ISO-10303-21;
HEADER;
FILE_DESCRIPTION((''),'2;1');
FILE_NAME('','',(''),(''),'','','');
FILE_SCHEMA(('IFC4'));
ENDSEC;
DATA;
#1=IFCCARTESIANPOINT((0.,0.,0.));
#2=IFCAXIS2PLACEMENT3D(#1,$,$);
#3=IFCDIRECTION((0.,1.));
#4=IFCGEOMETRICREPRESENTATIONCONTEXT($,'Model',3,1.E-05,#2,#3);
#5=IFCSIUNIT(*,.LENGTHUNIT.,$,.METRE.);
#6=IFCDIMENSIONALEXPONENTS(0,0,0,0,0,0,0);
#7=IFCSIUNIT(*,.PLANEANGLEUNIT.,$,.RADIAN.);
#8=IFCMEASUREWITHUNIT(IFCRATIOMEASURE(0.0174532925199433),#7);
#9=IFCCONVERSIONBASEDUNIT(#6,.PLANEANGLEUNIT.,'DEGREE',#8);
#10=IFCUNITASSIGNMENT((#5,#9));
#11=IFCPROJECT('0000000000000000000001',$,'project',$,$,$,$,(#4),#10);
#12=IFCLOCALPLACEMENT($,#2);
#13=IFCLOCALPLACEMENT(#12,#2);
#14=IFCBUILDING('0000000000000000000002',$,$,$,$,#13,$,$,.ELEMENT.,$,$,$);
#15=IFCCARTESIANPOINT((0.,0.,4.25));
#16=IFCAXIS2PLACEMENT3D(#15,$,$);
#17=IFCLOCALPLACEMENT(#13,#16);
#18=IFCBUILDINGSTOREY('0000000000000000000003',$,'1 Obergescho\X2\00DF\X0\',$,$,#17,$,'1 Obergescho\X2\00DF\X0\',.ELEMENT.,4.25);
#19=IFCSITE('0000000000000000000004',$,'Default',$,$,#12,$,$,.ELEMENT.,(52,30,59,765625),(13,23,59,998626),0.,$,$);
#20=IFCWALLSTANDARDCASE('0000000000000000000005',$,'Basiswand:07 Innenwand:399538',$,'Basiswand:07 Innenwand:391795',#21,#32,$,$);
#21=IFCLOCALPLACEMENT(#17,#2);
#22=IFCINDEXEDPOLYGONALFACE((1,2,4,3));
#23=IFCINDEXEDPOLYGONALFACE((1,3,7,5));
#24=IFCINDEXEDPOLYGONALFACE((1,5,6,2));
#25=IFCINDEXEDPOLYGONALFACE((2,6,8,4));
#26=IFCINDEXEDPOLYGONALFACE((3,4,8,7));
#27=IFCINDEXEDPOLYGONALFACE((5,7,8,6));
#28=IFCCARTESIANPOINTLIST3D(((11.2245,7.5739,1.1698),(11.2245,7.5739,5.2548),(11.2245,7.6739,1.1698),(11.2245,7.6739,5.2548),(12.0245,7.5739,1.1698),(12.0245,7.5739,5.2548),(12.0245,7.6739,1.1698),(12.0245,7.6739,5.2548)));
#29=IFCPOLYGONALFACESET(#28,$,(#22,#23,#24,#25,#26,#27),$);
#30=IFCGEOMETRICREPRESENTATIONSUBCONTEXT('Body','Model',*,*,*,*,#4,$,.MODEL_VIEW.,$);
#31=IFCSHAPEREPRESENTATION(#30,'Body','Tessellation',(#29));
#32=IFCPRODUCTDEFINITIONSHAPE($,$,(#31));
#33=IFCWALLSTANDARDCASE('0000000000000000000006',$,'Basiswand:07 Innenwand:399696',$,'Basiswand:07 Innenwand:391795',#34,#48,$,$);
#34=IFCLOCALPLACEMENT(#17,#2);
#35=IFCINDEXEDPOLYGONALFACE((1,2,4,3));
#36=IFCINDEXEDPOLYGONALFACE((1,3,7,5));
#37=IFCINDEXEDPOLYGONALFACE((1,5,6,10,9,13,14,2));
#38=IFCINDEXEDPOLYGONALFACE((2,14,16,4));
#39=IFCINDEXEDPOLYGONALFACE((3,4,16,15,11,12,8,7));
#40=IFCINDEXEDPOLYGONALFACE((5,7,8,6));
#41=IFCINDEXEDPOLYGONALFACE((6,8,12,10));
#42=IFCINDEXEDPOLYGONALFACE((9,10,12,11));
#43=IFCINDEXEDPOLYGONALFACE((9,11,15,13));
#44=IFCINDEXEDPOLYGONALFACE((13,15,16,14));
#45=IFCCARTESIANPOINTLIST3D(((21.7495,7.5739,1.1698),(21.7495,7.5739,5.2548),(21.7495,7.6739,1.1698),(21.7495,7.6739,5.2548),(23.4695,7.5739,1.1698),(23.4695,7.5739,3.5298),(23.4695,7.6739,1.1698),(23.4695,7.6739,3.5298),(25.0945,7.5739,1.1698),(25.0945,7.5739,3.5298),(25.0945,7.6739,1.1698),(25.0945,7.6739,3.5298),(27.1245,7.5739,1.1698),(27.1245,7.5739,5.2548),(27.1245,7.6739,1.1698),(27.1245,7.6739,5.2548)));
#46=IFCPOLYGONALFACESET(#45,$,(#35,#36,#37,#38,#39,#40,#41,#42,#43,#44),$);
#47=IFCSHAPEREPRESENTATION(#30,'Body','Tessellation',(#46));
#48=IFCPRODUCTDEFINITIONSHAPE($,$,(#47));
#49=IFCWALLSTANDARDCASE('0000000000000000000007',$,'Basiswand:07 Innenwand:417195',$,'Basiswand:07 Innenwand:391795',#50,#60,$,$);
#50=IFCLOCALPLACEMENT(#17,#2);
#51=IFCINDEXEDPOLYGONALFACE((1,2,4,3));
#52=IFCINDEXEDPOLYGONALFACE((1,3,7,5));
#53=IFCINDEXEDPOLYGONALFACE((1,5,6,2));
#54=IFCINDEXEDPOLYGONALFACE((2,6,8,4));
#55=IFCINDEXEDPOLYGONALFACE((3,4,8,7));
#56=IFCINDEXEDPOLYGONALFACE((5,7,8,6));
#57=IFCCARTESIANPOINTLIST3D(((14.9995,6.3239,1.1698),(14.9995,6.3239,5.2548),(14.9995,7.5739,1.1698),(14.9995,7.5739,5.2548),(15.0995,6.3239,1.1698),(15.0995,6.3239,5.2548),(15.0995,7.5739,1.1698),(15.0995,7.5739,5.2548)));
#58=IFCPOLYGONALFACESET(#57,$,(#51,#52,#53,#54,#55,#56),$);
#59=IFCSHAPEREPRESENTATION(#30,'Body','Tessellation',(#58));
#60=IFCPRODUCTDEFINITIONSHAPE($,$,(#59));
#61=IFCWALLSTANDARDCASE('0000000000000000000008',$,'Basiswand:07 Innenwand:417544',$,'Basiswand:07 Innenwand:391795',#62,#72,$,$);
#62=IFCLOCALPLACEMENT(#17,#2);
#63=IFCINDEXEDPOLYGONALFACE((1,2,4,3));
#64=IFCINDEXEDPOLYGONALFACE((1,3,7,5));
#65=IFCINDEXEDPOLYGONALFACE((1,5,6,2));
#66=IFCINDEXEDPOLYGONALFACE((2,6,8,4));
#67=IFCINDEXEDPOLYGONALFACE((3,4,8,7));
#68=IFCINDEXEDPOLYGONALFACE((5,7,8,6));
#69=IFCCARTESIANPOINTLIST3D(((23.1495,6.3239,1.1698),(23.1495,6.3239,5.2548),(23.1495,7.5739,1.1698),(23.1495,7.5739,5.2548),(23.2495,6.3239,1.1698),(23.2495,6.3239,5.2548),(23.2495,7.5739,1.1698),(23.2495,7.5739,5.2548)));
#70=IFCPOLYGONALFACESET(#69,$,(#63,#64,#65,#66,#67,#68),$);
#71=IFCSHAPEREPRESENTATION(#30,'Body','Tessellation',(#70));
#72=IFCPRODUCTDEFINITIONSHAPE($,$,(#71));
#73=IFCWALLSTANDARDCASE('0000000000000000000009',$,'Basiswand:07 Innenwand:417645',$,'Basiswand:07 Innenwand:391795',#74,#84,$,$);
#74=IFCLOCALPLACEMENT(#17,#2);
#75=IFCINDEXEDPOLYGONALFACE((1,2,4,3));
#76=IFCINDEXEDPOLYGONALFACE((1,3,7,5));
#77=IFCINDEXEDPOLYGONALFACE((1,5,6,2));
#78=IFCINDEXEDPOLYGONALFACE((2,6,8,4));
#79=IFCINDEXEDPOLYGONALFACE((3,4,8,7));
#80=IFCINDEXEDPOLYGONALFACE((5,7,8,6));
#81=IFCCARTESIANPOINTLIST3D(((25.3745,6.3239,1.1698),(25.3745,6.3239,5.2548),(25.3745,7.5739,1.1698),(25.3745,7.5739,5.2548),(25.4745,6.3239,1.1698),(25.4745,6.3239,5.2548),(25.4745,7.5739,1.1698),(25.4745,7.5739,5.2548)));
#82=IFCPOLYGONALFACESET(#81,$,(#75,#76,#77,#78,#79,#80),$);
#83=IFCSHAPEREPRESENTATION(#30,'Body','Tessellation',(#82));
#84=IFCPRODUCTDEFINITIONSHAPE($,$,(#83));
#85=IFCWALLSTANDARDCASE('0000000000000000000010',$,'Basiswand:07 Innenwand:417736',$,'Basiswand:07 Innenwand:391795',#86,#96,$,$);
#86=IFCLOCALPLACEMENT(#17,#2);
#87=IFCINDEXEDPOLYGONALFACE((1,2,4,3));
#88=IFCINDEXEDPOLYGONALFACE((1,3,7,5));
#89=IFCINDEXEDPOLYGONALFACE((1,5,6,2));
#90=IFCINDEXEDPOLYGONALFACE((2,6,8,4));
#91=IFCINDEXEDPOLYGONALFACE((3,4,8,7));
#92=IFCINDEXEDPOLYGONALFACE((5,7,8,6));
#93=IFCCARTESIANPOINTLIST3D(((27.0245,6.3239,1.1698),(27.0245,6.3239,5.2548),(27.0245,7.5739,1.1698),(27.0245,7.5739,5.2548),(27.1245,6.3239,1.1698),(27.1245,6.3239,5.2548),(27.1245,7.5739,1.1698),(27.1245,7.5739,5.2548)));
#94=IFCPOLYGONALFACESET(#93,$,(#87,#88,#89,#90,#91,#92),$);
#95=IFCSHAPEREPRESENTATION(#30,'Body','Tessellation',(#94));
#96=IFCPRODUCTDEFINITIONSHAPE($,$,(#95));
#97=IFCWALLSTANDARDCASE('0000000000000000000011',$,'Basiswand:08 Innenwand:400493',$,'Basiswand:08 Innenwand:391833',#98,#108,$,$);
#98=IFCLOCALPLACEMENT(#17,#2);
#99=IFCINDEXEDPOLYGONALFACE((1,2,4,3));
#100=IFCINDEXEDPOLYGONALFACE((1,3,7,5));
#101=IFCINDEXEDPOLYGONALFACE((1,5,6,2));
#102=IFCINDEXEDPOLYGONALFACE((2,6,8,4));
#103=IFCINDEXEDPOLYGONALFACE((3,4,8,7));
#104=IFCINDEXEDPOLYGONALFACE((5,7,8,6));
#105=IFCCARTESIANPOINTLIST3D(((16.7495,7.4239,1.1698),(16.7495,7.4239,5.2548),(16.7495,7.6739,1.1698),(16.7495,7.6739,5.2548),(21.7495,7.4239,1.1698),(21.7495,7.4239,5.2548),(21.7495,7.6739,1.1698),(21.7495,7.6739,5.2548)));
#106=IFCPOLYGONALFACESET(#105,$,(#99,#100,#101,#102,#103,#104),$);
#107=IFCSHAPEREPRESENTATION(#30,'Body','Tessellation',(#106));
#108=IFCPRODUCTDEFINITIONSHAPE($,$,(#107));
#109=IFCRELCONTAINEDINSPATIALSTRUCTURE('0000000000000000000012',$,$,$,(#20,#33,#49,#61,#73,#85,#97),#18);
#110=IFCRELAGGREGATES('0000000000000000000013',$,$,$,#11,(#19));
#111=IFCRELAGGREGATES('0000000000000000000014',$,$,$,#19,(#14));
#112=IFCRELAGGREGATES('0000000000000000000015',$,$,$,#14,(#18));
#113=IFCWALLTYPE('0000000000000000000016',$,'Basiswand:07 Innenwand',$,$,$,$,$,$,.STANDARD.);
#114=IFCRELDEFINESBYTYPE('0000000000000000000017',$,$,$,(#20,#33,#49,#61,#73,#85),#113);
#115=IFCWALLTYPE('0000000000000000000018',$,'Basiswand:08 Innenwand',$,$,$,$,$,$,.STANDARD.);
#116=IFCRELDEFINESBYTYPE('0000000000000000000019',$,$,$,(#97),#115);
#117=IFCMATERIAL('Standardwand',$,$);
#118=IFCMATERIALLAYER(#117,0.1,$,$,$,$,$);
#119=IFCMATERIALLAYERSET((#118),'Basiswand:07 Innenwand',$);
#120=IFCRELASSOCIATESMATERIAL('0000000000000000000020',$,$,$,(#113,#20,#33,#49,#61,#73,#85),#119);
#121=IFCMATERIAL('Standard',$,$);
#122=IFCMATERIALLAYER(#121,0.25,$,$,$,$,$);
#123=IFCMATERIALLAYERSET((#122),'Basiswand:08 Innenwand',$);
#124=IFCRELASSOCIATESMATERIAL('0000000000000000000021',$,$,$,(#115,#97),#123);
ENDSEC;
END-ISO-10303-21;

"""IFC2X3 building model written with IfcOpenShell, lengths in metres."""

from ifc_helpers import new_model, entity, si_unit, converted_unit, direction, frame, frame_2d, origin, place, context, subcontext, project, spatial, polyline, rectangle, extrude, clip, bounded_halfspace, material, layer, layer_set, layer_usage, type_object, element, save


model = new_model("IFC2X3")

# Units and contexts
model_context = context("Model", 3, precision=1e-05, world=origin(), true_north=direction((0.0, 1.0)))
body_context = subcontext(model_context, "Body", "Model", "MODEL_VIEW")
ifc_project = project(units=[si_unit("LENGTHUNIT", "METRE"), converted_unit("PLANEANGLEUNIT", "DEGREE", entity("IfcRatioMeasure", 0.0174532925199433), si_unit("PLANEANGLEUNIT", "RADIAN"), dimensions=[0, 0, 0, 0, 0, 0, 0])], contexts=[model_context])

# Site, building, storey
site_placement = place(None, origin())
site = spatial("IfcSite", under=ifc_project, at=site_placement, Name="Default", CompositionType="ELEMENT", RefLatitude=(52, 30, 59, 765625), RefLongitude=(13, 23, 59, 998626), RefElevation=0.0)
building_placement = place(site_placement, origin())
building = spatial("IfcBuilding", under=site, at=building_placement, CompositionType="ELEMENT")
storey_placement = place(building_placement, frame((0.0, 0.0, 4.25)))
storey = spatial("IfcBuildingStorey", under=building, at=storey_placement, Name="1 Obergeschoß", LongName="1 Obergeschoß", CompositionType="ELEMENT", Elevation=4.25)

# Shared definitions
ifc_material_1 = material(Name="Standardwand")
ifc_layer_1 = layer(ifc_material_1, 0.1)
ifc_layer_set_1 = layer_set([ifc_layer_1], Name="Basiswand:07 Innenwand")
wall_type_1 = type_object("IfcWallType", Name="Basiswand:07 Innenwand", PredefinedType="STANDARD", material=ifc_layer_set_1)

# Wall
ifc_layer_usage_1 = layer_usage(ifc_layer_set_1, "AXIS2", "NEGATIVE", 0.05)
wall_1_placement = place(storey_placement, frame((11.2245, 7.6239, 1.1698), z_axis=(0.0, 0.0, 1.0), x_axis=(1.0, 0.0, 0.0)))
element("IfcWallStandardCase", 1, at=wall_1_placement, inside=storey, type_object=wall_type_1, material=ifc_layer_usage_1, Name="Basiswand:07 Innenwand:399538", ObjectType="Basiswand:07 Innenwand:391795", context=body_context, shape_type="Clipping", body=[
    clip(extrude(rectangle(XDim=0.8, YDim=0.1, at=frame_2d((0.4, 0.0), x_axis=(-1.0, 0.0))), origin(), (0.0, 0.0, 1.0), 4.085), bounded_halfspace(frame((0.0, -0.05, 4.085), z_axis=(0.0, 0.0, -1.0), x_axis=(0.0, -1.0, 0.0)), True, frame((0.0, -0.05, 4.085)), polyline([(0.0, 0.0), (0.8, 0.0), (0.8, 0.1), (0.0, 0.1), (0.0, 0.0)]))),
])

# Wall, opening
ifc_layer_usage_2 = layer_usage(ifc_layer_set_1, "AXIS2", "POSITIVE", -0.05)
wall_2_placement = place(storey_placement, frame((21.7495, 7.6239, 1.1698), z_axis=(0.0, 0.0, 1.0), x_axis=(1.0, 0.0, 0.0)))
wall_2 = element("IfcWallStandardCase", 2, at=wall_2_placement, inside=storey, type_object=wall_type_1, material=ifc_layer_usage_2, Name="Basiswand:07 Innenwand:399696", ObjectType="Basiswand:07 Innenwand:391795", context=body_context, shape_type="Clipping", body=[
    clip(extrude(rectangle(XDim=5.375, YDim=0.1, at=frame_2d((2.6875, 0.0), x_axis=(-1.0, 0.0))), origin(), (0.0, 0.0, 1.0), 4.085), bounded_halfspace(frame((0.0, -0.05, 4.085), z_axis=(0.0, 0.0, -1.0), x_axis=(0.0, -1.0, 0.0)), True, frame((0.0, -0.05, 4.085)), polyline([(0.0, 0.0), (1.4, 0.0), (1.5, 0.0), (3.625, 0.0), (3.725, 0.0), (5.275, 0.0), (5.375, 0.0), (5.375, 0.1), (0.0, 0.1), (0.0, 0.0)]))),
])
opening_1_placement = place(wall_2_placement, frame((3.345, 0.05, 0.0)))
element("IfcOpeningElement", 3, at=opening_1_placement, cuts=wall_2, ObjectType="Opening", context=body_context, shape_type="SweptSolid", body=[
    extrude(rectangle(XDim=2.36, YDim=1.625, at=frame_2d((1.18, 0.8125), x_axis=(1.0, 0.0))), frame((0.0, 0.0, 0.0), z_axis=(0.0, -1.0, 0.0), x_axis=(0.0, 0.0, 1.0)), (0.0, 0.0, 1.0), 0.1),
])

# Walls
ifc_layer_usage_3 = layer_usage(ifc_layer_set_1, "AXIS2", "NEGATIVE", 0.05)
wall_3_placement = place(storey_placement, frame((15.0495, 7.5739, 1.1698), z_axis=(0.0, 0.0, 1.0), x_axis=(0.0, -1.0, 0.0)))
element("IfcWallStandardCase", 4, at=wall_3_placement, inside=storey, type_object=wall_type_1, material=ifc_layer_usage_3, Name="Basiswand:07 Innenwand:417195", ObjectType="Basiswand:07 Innenwand:391795", context=body_context, shape_type="Clipping", body=[
    clip(extrude(rectangle(XDim=1.25, YDim=0.1, at=frame_2d((0.625, 0.0), x_axis=(-1.0, 0.0))), origin(), (0.0, 0.0, 1.0), 4.085), bounded_halfspace(frame((0.0, -0.05, 4.085), z_axis=(0.0, 0.0, -1.0), x_axis=(1.0, 0.0, 0.0)), True, frame((0.0, -0.05, 4.085)), polyline([(0.0, 0.0), (1.25, 0.0), (1.25, 0.1), (0.0, 0.1), (0.0, 0.0)]))),
])
ifc_layer_usage_4 = layer_usage(ifc_layer_set_1, "AXIS2", "NEGATIVE", 0.05)
wall_4_placement = place(storey_placement, frame((23.1995, 7.5739, 1.1698), z_axis=(0.0, 0.0, 1.0), x_axis=(0.0, -1.0, 0.0)))
element("IfcWallStandardCase", 5, at=wall_4_placement, inside=storey, type_object=wall_type_1, material=ifc_layer_usage_4, Name="Basiswand:07 Innenwand:417544", ObjectType="Basiswand:07 Innenwand:391795", context=body_context, shape_type="Clipping", body=[
    clip(extrude(rectangle(XDim=1.25, YDim=0.1, at=frame_2d((0.625, 0.0), x_axis=(-1.0, 0.0))), origin(), (0.0, 0.0, 1.0), 4.085), bounded_halfspace(frame((0.0, -0.05, 4.085), z_axis=(0.0, 0.0, -1.0), x_axis=(1.0, 0.0, 0.0)), True, frame((0.0, -0.05, 4.085)), polyline([(0.0, 0.0), (1.25, 0.0), (1.25, 0.1), (0.0, 0.1), (0.0, 0.0)]))),
])
ifc_layer_usage_5 = layer_usage(ifc_layer_set_1, "AXIS2", "NEGATIVE", 0.05)
wall_5_placement = place(storey_placement, frame((25.4245, 7.5739, 1.1698), z_axis=(0.0, 0.0, 1.0), x_axis=(0.0, -1.0, 0.0)))
element("IfcWallStandardCase", 6, at=wall_5_placement, inside=storey, type_object=wall_type_1, material=ifc_layer_usage_5, Name="Basiswand:07 Innenwand:417645", ObjectType="Basiswand:07 Innenwand:391795", context=body_context, shape_type="Clipping", body=[
    clip(extrude(rectangle(XDim=1.25, YDim=0.1, at=frame_2d((0.625, 0.0), x_axis=(-1.0, 0.0))), origin(), (0.0, 0.0, 1.0), 4.085), bounded_halfspace(frame((0.0, -0.05, 4.085), z_axis=(0.0, 0.0, -1.0), x_axis=(1.0, 0.0, 0.0)), True, frame((0.0, -0.05, 4.085)), polyline([(0.0, 0.0), (1.25, 0.0), (1.25, 0.1), (0.0, 0.1), (0.0, 0.0)]))),
])
ifc_layer_usage_6 = layer_usage(ifc_layer_set_1, "AXIS2", "POSITIVE", -0.05)
wall_6_placement = place(storey_placement, frame((27.0745, 7.5739, 1.1698), z_axis=(0.0, 0.0, 1.0), x_axis=(0.0, -1.0, 0.0)))
element("IfcWallStandardCase", 7, at=wall_6_placement, inside=storey, type_object=wall_type_1, material=ifc_layer_usage_6, Name="Basiswand:07 Innenwand:417736", ObjectType="Basiswand:07 Innenwand:391795", context=body_context, shape_type="Clipping", body=[
    clip(extrude(rectangle(XDim=1.25, YDim=0.1, at=frame_2d((0.625, 0.0), x_axis=(-1.0, 0.0))), origin(), (0.0, 0.0, 1.0), 4.085), bounded_halfspace(frame((0.0, -0.05, 4.085), z_axis=(0.0, 0.0, -1.0), x_axis=(1.0, 0.0, 0.0)), True, frame((0.0, -0.05, 4.085)), polyline([(0.0, 0.0), (1.25, 0.0), (1.25, 0.1), (0.0, 0.1), (0.0, 0.0)]))),
])
ifc_material_2 = material(Name="Standard")
ifc_layer_2 = layer(ifc_material_2, 0.25)
ifc_layer_set_2 = layer_set([ifc_layer_2], Name="Basiswand:08 Innenwand")
ifc_layer_usage_7 = layer_usage(ifc_layer_set_2, "AXIS2", "NEGATIVE", 0.125)
wall_type_2 = type_object("IfcWallType", Name="Basiswand:08 Innenwand", PredefinedType="STANDARD", material=ifc_layer_set_2)
wall_7_placement = place(storey_placement, frame((16.7495, 7.5489, 1.1698), z_axis=(0.0, 0.0, 1.0), x_axis=(1.0, 0.0, 0.0)))
element("IfcWallStandardCase", 8, at=wall_7_placement, inside=storey, type_object=wall_type_2, material=ifc_layer_usage_7, Name="Basiswand:08 Innenwand:400493", ObjectType="Basiswand:08 Innenwand:391833", context=body_context, shape_type="Clipping", body=[
    clip(extrude(rectangle(XDim=5.0, YDim=0.25, at=frame_2d((2.5, 0.0), x_axis=(-1.0, 0.0))), origin(), (0.0, 0.0, 1.0), 4.085), bounded_halfspace(frame((0.0, -0.125, 4.085), z_axis=(0.0, 0.0, -1.0), x_axis=(0.0, -1.0, 0.0)), True, frame((0.0, -0.125, 4.085)), polyline([(0.0, 0.0), (4.75, 0.0), (5.0, 0.0), (5.0, 0.15), (5.0, 0.25), (0.0, 0.25), (0.0, 0.0)]))),
])

save(model, "model.ifc")
